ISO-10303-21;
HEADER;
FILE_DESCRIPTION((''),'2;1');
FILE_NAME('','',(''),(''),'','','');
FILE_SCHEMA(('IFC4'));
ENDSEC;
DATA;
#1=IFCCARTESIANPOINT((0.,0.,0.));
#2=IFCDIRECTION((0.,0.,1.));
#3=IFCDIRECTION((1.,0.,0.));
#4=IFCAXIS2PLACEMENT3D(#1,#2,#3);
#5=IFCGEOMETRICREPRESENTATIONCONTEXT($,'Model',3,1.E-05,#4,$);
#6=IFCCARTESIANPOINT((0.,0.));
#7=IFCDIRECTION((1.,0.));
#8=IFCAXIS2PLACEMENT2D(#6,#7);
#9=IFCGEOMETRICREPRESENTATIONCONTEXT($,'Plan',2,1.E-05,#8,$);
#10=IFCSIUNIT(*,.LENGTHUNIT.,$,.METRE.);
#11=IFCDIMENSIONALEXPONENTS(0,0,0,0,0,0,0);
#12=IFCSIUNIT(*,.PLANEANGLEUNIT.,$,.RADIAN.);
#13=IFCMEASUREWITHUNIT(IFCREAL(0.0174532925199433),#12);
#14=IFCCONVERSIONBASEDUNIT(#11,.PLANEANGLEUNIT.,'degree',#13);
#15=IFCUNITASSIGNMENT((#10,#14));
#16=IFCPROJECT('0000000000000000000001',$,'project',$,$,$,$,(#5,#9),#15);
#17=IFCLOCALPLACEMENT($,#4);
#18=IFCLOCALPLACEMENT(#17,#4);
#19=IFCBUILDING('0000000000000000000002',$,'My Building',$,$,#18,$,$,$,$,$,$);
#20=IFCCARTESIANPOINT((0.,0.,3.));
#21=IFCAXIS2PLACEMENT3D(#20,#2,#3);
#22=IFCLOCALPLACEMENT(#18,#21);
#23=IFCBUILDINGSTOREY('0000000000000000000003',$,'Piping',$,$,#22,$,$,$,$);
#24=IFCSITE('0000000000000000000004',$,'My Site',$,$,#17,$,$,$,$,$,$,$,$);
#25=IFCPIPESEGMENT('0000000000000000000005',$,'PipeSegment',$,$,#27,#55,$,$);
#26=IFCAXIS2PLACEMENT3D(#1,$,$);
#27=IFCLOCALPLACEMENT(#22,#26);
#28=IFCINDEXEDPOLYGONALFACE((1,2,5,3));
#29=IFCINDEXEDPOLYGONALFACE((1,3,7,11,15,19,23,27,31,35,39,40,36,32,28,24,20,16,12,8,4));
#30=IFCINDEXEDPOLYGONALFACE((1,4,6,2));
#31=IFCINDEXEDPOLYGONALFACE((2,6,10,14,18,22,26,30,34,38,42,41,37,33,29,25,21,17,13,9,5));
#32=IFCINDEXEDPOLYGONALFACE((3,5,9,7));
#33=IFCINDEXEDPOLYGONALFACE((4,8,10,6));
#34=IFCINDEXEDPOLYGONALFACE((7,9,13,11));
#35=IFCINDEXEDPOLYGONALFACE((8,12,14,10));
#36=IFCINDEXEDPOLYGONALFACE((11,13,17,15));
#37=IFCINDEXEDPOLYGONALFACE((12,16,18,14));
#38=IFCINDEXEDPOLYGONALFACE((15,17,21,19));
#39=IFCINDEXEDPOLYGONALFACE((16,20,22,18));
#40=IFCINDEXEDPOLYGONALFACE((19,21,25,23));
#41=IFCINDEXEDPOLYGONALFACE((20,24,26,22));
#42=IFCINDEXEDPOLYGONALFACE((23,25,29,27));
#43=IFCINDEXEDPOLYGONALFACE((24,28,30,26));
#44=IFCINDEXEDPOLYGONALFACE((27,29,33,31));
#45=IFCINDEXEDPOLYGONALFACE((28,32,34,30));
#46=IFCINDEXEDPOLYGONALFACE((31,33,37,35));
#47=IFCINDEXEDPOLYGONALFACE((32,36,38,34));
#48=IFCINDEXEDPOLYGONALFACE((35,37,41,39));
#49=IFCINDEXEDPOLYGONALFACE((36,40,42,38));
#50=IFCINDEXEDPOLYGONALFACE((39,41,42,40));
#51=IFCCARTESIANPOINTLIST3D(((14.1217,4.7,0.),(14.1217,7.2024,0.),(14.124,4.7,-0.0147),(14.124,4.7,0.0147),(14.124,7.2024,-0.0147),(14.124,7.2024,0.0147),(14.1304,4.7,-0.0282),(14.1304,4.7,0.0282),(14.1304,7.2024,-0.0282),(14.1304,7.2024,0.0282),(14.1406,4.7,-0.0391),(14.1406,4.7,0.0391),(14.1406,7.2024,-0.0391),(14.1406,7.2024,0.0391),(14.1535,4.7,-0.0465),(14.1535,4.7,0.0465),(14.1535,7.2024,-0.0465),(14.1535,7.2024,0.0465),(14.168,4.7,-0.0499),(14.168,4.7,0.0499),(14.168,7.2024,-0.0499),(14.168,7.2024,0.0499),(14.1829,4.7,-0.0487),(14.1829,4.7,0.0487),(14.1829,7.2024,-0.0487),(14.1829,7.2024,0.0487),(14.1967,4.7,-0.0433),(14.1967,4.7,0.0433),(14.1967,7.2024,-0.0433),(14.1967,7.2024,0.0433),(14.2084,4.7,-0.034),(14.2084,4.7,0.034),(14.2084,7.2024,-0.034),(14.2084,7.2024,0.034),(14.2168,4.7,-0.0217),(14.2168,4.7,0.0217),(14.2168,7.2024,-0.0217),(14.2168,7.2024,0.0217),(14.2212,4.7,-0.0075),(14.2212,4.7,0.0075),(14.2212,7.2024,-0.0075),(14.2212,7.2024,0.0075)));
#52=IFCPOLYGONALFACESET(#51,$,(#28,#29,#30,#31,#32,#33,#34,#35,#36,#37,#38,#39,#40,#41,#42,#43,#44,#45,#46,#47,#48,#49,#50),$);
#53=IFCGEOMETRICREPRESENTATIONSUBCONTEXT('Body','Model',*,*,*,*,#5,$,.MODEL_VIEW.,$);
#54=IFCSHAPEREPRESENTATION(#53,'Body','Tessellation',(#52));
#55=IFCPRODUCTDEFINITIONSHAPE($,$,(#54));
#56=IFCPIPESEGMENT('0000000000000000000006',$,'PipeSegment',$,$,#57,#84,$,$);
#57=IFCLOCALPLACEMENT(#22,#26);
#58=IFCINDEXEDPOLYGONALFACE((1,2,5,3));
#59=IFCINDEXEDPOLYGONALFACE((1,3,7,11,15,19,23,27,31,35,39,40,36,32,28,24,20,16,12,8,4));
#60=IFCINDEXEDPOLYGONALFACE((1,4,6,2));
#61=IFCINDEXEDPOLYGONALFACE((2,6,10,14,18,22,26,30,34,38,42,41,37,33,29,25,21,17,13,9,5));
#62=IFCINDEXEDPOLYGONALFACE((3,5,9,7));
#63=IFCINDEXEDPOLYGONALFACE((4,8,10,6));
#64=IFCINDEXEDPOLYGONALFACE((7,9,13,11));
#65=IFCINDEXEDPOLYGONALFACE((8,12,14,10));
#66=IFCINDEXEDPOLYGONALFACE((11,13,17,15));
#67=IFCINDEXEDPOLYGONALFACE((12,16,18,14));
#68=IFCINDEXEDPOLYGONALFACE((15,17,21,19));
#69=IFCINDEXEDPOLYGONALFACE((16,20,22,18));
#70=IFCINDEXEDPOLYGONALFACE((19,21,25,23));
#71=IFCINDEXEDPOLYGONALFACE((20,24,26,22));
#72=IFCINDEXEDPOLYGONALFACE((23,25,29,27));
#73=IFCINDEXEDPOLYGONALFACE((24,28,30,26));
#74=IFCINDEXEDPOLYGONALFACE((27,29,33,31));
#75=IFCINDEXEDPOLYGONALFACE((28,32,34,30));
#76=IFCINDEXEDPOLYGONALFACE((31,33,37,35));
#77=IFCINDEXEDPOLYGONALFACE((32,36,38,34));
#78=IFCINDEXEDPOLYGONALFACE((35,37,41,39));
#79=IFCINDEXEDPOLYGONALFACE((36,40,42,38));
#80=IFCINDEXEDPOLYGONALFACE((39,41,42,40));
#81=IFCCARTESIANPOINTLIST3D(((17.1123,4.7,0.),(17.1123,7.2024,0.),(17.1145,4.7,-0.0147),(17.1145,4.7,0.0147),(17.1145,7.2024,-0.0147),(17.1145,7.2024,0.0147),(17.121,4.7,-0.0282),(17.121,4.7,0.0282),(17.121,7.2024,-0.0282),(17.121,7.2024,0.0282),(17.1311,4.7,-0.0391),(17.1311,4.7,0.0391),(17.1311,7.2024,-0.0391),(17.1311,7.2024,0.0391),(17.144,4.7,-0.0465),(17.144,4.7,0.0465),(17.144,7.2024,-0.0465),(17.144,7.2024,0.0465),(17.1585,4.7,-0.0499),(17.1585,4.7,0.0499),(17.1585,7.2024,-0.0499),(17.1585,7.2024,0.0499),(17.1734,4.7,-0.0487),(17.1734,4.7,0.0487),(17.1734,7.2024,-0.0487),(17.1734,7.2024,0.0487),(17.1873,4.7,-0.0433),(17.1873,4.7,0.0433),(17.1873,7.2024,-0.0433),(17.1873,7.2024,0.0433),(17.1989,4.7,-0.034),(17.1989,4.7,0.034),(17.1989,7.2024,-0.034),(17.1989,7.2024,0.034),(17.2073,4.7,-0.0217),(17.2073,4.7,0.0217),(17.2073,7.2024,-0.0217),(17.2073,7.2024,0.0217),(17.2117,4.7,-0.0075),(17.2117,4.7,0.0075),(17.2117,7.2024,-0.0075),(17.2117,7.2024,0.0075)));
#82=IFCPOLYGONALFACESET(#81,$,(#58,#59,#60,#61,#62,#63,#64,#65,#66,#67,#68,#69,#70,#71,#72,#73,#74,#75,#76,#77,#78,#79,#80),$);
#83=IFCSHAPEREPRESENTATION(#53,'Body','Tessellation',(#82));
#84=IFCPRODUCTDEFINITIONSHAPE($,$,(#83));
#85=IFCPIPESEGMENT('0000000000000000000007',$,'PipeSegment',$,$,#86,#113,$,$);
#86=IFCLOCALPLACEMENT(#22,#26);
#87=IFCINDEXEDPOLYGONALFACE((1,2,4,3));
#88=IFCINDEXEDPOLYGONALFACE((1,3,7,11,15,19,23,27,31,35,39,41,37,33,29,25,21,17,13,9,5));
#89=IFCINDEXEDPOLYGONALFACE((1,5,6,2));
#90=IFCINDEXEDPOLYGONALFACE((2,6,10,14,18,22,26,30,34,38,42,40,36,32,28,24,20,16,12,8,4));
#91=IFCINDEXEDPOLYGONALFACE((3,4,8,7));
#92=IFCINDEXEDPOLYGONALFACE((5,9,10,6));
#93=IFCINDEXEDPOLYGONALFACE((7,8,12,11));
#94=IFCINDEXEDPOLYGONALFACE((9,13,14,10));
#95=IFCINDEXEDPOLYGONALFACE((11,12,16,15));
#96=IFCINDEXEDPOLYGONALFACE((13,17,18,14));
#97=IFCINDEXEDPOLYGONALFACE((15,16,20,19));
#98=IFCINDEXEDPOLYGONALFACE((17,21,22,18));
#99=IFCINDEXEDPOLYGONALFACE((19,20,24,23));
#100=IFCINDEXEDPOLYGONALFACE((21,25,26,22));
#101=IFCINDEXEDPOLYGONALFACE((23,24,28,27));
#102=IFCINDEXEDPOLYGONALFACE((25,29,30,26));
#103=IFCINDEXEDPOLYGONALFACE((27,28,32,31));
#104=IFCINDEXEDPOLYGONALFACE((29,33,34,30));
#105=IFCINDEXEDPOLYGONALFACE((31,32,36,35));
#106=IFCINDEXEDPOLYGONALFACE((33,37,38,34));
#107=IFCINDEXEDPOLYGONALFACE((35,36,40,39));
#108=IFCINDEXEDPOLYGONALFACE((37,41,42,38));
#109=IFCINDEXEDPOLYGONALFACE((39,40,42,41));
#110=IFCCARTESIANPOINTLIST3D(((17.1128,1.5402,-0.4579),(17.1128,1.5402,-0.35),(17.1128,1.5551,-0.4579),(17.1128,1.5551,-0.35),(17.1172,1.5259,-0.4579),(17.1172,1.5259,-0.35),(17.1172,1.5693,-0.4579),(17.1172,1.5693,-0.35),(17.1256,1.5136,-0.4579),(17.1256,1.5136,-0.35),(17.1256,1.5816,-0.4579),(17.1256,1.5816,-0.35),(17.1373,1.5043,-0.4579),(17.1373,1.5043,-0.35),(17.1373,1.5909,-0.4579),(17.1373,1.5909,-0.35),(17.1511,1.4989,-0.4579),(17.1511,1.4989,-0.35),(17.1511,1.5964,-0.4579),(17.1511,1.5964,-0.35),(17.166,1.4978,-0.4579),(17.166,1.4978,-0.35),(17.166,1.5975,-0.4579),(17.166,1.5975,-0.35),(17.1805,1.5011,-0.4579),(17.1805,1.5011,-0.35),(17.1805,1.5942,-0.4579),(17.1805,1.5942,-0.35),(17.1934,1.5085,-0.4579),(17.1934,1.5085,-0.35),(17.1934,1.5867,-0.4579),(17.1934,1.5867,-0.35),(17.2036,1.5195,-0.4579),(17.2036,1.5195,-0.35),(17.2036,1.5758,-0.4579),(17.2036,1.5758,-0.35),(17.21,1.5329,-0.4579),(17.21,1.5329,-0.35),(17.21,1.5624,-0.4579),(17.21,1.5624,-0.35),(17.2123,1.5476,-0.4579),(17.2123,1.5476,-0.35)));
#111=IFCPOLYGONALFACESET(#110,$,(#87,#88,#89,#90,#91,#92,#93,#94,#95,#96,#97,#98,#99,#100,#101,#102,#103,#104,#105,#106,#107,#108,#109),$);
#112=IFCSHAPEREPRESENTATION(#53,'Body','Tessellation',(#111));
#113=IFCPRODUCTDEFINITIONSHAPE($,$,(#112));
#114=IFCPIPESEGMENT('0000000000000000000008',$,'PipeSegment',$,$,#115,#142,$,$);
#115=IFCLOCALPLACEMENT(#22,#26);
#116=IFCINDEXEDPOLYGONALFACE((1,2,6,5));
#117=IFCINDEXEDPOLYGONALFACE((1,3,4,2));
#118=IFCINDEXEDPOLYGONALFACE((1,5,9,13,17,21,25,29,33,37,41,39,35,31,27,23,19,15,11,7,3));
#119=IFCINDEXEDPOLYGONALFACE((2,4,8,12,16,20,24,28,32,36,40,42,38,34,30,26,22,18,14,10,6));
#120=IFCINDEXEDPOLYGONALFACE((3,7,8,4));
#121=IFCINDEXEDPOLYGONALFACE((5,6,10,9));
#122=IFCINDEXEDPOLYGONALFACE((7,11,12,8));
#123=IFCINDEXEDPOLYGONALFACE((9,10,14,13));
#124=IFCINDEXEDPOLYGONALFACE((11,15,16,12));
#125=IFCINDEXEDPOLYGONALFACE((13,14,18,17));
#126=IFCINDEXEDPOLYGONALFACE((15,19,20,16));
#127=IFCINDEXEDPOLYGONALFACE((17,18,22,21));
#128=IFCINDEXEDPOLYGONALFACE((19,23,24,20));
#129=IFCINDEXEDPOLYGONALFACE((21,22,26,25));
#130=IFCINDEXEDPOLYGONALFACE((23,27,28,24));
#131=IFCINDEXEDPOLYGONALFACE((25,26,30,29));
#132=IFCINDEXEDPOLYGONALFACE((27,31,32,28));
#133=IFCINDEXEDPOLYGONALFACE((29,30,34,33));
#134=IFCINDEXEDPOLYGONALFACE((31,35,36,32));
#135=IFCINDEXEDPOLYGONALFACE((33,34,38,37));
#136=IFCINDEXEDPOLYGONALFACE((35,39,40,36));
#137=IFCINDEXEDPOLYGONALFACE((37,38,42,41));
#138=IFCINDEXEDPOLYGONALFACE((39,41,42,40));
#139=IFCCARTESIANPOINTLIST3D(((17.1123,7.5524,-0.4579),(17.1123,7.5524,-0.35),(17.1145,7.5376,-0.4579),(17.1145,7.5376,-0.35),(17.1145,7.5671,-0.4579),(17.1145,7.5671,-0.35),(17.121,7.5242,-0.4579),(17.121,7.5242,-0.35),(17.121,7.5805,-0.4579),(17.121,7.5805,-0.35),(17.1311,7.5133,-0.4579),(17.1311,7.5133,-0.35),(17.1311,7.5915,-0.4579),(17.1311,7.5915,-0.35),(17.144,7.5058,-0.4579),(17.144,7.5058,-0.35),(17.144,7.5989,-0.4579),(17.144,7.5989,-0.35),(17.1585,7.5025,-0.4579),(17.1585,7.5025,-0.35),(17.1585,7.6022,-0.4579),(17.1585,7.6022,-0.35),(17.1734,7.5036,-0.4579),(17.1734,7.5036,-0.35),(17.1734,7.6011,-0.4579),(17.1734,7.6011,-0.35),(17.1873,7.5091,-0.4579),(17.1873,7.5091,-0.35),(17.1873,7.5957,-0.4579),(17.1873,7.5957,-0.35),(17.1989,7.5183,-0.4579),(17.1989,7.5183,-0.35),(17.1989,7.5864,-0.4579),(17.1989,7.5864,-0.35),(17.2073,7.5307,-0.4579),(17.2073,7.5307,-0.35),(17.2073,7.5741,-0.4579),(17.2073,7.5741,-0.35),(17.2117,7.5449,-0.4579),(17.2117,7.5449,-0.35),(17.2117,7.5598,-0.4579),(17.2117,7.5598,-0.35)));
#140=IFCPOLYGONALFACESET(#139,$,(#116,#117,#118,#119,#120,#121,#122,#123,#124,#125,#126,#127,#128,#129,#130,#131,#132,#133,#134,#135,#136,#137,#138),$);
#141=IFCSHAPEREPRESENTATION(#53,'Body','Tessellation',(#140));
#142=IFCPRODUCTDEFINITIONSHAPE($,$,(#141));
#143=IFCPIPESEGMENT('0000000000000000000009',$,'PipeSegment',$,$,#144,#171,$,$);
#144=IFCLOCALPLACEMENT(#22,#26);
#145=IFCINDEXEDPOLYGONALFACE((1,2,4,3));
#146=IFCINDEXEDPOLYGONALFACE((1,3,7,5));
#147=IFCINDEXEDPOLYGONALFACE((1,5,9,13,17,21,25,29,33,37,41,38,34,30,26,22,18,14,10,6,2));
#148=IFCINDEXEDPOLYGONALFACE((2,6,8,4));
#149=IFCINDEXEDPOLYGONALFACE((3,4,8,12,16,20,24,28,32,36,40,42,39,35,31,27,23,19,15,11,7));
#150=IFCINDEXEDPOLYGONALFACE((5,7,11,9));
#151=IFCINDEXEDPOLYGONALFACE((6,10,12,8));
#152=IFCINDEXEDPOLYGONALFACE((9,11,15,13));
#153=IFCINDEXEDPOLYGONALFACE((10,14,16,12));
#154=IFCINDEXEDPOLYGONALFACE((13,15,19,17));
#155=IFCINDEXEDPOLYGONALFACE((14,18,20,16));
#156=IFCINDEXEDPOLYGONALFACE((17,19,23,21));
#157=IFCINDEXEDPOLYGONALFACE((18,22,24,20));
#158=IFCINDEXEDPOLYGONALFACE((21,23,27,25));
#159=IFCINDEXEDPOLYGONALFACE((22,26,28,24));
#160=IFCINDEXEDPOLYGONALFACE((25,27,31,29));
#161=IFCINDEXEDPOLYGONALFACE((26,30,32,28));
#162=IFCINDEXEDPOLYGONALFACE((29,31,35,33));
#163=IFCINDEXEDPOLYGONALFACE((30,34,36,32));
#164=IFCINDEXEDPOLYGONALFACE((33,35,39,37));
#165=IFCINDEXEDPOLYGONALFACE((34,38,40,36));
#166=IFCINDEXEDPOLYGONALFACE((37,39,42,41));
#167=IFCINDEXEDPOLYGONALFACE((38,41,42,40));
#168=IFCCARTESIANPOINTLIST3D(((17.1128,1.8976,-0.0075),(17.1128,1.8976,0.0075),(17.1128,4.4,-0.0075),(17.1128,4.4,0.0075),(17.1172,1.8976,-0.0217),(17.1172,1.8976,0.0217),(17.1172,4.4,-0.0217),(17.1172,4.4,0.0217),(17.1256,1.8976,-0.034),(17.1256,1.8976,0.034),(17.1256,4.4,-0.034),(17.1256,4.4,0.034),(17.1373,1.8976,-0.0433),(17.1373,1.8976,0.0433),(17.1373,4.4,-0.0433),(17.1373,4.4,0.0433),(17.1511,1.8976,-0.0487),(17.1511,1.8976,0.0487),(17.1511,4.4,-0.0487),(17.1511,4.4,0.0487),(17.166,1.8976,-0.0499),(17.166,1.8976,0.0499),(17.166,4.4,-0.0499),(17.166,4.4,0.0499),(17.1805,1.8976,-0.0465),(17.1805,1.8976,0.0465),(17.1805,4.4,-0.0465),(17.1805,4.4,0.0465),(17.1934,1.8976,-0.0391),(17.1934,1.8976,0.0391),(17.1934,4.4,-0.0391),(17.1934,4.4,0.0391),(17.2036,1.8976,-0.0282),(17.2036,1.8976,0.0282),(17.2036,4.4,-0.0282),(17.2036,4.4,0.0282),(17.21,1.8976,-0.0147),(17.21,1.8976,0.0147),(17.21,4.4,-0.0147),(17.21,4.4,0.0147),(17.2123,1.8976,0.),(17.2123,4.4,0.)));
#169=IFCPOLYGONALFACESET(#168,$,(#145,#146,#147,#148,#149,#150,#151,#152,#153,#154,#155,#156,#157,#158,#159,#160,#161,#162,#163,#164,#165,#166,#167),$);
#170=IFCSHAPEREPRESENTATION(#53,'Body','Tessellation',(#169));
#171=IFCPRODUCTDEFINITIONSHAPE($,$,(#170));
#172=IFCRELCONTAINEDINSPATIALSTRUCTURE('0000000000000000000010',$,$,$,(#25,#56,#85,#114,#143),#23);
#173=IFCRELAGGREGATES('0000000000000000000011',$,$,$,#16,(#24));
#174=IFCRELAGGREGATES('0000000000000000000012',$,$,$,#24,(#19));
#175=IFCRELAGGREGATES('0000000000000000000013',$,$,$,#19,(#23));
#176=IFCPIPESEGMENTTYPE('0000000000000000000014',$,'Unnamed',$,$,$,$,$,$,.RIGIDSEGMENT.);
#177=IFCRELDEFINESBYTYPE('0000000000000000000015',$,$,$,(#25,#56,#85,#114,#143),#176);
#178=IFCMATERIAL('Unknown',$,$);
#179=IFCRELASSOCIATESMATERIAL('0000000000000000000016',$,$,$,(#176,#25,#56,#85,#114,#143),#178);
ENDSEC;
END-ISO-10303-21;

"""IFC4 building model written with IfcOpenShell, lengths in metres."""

from ifc_helpers import new_model, entity, si_unit, converted_unit, frame, origin_with_axes, origin_2d_with_axis, place, context, subcontext, project, spatial, circle, extrude, material, material_profile, profile_set, profile_usage, type_object, element, save


model = new_model("IFC4")

# Units and contexts
model_context = context("Model", 3, precision=1e-05, world=origin_with_axes())
plan_context = context("Plan", 2, precision=1e-05, world=origin_2d_with_axis())
body_context = subcontext(model_context, "Body", "Model", "MODEL_VIEW")
ifc_project = project(units=[si_unit("LENGTHUNIT", "METRE"), converted_unit("PLANEANGLEUNIT", "degree", entity("IfcReal", 0.0174532925199433), si_unit("PLANEANGLEUNIT", "RADIAN"), dimensions=[0, 0, 0, 0, 0, 0, 0])], contexts=[model_context, plan_context])

# Site, building, storey
site_placement = place(None, origin_with_axes())
site = spatial("IfcSite", under=ifc_project, at=site_placement, Name="My Site")
building_placement = place(site_placement, origin_with_axes())
building = spatial("IfcBuilding", under=site, at=building_placement, Name="My Building")
storey_placement = place(building_placement, frame((0.0, 0.0, 3.0), z_axis=(0.0, 0.0, 1.0), x_axis=(1.0, 0.0, 0.0)))
storey = spatial("IfcBuildingStorey", under=building, at=storey_placement, Name="Piping")

# Pipe segments
ifc_material = material(Name="Unknown")
ifc_material_profile_1 = material_profile(ifc_material, circle(Radius=0.05))
ifc_profile_set_1 = profile_set([ifc_material_profile_1])
pipe_segment_type = type_object("IfcPipeSegmentType", Name="Unnamed", PredefinedType="RIGIDSEGMENT", material=ifc_profile_set_1)
ifc_profile_usage_1 = profile_usage(ifc_profile_set_1, cardinal=5)
pipe_segment_1_placement = place(storey_placement, frame((14.1717, 4.7, 0.0), z_axis=(0.0, 1.0, 0.0), x_axis=(-1.0, 0.0, 0.0)))
element("IfcPipeSegment", 1, at=pipe_segment_1_placement, inside=storey, type_object=pipe_segment_type, material=ifc_profile_usage_1, Name="PipeSegment", context=body_context, shape_type="SweptSolid", body=[
    extrude(circle(Radius=0.05), origin_with_axes(), (0.0, 0.0, 1.0), 2.5024),
])
ifc_profile_usage_2 = profile_usage(ifc_profile_set_1, cardinal=5)
pipe_segment_2_placement = place(storey_placement, frame((17.1623, 4.7, 0.0), z_axis=(0.0, 1.0, 0.0), x_axis=(-1.0, 0.0, 0.0)))
element("IfcPipeSegment", 2, at=pipe_segment_2_placement, inside=storey, type_object=pipe_segment_type, material=ifc_profile_usage_2, Name="PipeSegment", context=body_context, shape_type="SweptSolid", body=[
    extrude(circle(Radius=0.05), origin_with_axes(), (0.0, 0.0, 1.0), 2.5024),
])
ifc_profile_usage_3 = profile_usage(ifc_profile_set_1, cardinal=5)
pipe_segment_3_placement = place(storey_placement, frame((17.1623, 1.5476, -0.35), z_axis=(0.0, 0.0, -1.0), x_axis=(1.0, 0.0, 0.0)))
element("IfcPipeSegment", 3, at=pipe_segment_3_placement, inside=storey, type_object=pipe_segment_type, material=ifc_profile_usage_3, Name="PipeSegment", context=body_context, shape_type="SweptSolid", body=[
    extrude(circle(Radius=0.05), origin_with_axes(), (0.0, 0.0, 1.0), 0.1079),
])
ifc_profile_usage_4 = profile_usage(ifc_profile_set_1, cardinal=5)
pipe_segment_4_placement = place(storey_placement, frame((17.1623, 7.5524, -0.35), z_axis=(0.0, 0.0, -1.0), x_axis=(-1.0, 0.0, 0.0)))
element("IfcPipeSegment", 4, at=pipe_segment_4_placement, inside=storey, type_object=pipe_segment_type, material=ifc_profile_usage_4, Name="PipeSegment", context=body_context, shape_type="SweptSolid", body=[
    extrude(circle(Radius=0.05), origin_with_axes(), (0.0, 0.0, 1.0), 0.1079),
])
ifc_profile_usage_5 = profile_usage(ifc_profile_set_1, cardinal=5)
pipe_segment_5_placement = place(storey_placement, frame((17.1623, 4.4, 0.0), z_axis=(0.0, -1.0, 0.0), x_axis=(1.0, 0.0, 0.0)))
element("IfcPipeSegment", 5, at=pipe_segment_5_placement, inside=storey, type_object=pipe_segment_type, material=ifc_profile_usage_5, Name="PipeSegment", context=body_context, shape_type="SweptSolid", body=[
    extrude(circle(Radius=0.05), origin_with_axes(), (0.0, 0.0, 1.0), 2.5024),
])

save(model, "model.ifc")
